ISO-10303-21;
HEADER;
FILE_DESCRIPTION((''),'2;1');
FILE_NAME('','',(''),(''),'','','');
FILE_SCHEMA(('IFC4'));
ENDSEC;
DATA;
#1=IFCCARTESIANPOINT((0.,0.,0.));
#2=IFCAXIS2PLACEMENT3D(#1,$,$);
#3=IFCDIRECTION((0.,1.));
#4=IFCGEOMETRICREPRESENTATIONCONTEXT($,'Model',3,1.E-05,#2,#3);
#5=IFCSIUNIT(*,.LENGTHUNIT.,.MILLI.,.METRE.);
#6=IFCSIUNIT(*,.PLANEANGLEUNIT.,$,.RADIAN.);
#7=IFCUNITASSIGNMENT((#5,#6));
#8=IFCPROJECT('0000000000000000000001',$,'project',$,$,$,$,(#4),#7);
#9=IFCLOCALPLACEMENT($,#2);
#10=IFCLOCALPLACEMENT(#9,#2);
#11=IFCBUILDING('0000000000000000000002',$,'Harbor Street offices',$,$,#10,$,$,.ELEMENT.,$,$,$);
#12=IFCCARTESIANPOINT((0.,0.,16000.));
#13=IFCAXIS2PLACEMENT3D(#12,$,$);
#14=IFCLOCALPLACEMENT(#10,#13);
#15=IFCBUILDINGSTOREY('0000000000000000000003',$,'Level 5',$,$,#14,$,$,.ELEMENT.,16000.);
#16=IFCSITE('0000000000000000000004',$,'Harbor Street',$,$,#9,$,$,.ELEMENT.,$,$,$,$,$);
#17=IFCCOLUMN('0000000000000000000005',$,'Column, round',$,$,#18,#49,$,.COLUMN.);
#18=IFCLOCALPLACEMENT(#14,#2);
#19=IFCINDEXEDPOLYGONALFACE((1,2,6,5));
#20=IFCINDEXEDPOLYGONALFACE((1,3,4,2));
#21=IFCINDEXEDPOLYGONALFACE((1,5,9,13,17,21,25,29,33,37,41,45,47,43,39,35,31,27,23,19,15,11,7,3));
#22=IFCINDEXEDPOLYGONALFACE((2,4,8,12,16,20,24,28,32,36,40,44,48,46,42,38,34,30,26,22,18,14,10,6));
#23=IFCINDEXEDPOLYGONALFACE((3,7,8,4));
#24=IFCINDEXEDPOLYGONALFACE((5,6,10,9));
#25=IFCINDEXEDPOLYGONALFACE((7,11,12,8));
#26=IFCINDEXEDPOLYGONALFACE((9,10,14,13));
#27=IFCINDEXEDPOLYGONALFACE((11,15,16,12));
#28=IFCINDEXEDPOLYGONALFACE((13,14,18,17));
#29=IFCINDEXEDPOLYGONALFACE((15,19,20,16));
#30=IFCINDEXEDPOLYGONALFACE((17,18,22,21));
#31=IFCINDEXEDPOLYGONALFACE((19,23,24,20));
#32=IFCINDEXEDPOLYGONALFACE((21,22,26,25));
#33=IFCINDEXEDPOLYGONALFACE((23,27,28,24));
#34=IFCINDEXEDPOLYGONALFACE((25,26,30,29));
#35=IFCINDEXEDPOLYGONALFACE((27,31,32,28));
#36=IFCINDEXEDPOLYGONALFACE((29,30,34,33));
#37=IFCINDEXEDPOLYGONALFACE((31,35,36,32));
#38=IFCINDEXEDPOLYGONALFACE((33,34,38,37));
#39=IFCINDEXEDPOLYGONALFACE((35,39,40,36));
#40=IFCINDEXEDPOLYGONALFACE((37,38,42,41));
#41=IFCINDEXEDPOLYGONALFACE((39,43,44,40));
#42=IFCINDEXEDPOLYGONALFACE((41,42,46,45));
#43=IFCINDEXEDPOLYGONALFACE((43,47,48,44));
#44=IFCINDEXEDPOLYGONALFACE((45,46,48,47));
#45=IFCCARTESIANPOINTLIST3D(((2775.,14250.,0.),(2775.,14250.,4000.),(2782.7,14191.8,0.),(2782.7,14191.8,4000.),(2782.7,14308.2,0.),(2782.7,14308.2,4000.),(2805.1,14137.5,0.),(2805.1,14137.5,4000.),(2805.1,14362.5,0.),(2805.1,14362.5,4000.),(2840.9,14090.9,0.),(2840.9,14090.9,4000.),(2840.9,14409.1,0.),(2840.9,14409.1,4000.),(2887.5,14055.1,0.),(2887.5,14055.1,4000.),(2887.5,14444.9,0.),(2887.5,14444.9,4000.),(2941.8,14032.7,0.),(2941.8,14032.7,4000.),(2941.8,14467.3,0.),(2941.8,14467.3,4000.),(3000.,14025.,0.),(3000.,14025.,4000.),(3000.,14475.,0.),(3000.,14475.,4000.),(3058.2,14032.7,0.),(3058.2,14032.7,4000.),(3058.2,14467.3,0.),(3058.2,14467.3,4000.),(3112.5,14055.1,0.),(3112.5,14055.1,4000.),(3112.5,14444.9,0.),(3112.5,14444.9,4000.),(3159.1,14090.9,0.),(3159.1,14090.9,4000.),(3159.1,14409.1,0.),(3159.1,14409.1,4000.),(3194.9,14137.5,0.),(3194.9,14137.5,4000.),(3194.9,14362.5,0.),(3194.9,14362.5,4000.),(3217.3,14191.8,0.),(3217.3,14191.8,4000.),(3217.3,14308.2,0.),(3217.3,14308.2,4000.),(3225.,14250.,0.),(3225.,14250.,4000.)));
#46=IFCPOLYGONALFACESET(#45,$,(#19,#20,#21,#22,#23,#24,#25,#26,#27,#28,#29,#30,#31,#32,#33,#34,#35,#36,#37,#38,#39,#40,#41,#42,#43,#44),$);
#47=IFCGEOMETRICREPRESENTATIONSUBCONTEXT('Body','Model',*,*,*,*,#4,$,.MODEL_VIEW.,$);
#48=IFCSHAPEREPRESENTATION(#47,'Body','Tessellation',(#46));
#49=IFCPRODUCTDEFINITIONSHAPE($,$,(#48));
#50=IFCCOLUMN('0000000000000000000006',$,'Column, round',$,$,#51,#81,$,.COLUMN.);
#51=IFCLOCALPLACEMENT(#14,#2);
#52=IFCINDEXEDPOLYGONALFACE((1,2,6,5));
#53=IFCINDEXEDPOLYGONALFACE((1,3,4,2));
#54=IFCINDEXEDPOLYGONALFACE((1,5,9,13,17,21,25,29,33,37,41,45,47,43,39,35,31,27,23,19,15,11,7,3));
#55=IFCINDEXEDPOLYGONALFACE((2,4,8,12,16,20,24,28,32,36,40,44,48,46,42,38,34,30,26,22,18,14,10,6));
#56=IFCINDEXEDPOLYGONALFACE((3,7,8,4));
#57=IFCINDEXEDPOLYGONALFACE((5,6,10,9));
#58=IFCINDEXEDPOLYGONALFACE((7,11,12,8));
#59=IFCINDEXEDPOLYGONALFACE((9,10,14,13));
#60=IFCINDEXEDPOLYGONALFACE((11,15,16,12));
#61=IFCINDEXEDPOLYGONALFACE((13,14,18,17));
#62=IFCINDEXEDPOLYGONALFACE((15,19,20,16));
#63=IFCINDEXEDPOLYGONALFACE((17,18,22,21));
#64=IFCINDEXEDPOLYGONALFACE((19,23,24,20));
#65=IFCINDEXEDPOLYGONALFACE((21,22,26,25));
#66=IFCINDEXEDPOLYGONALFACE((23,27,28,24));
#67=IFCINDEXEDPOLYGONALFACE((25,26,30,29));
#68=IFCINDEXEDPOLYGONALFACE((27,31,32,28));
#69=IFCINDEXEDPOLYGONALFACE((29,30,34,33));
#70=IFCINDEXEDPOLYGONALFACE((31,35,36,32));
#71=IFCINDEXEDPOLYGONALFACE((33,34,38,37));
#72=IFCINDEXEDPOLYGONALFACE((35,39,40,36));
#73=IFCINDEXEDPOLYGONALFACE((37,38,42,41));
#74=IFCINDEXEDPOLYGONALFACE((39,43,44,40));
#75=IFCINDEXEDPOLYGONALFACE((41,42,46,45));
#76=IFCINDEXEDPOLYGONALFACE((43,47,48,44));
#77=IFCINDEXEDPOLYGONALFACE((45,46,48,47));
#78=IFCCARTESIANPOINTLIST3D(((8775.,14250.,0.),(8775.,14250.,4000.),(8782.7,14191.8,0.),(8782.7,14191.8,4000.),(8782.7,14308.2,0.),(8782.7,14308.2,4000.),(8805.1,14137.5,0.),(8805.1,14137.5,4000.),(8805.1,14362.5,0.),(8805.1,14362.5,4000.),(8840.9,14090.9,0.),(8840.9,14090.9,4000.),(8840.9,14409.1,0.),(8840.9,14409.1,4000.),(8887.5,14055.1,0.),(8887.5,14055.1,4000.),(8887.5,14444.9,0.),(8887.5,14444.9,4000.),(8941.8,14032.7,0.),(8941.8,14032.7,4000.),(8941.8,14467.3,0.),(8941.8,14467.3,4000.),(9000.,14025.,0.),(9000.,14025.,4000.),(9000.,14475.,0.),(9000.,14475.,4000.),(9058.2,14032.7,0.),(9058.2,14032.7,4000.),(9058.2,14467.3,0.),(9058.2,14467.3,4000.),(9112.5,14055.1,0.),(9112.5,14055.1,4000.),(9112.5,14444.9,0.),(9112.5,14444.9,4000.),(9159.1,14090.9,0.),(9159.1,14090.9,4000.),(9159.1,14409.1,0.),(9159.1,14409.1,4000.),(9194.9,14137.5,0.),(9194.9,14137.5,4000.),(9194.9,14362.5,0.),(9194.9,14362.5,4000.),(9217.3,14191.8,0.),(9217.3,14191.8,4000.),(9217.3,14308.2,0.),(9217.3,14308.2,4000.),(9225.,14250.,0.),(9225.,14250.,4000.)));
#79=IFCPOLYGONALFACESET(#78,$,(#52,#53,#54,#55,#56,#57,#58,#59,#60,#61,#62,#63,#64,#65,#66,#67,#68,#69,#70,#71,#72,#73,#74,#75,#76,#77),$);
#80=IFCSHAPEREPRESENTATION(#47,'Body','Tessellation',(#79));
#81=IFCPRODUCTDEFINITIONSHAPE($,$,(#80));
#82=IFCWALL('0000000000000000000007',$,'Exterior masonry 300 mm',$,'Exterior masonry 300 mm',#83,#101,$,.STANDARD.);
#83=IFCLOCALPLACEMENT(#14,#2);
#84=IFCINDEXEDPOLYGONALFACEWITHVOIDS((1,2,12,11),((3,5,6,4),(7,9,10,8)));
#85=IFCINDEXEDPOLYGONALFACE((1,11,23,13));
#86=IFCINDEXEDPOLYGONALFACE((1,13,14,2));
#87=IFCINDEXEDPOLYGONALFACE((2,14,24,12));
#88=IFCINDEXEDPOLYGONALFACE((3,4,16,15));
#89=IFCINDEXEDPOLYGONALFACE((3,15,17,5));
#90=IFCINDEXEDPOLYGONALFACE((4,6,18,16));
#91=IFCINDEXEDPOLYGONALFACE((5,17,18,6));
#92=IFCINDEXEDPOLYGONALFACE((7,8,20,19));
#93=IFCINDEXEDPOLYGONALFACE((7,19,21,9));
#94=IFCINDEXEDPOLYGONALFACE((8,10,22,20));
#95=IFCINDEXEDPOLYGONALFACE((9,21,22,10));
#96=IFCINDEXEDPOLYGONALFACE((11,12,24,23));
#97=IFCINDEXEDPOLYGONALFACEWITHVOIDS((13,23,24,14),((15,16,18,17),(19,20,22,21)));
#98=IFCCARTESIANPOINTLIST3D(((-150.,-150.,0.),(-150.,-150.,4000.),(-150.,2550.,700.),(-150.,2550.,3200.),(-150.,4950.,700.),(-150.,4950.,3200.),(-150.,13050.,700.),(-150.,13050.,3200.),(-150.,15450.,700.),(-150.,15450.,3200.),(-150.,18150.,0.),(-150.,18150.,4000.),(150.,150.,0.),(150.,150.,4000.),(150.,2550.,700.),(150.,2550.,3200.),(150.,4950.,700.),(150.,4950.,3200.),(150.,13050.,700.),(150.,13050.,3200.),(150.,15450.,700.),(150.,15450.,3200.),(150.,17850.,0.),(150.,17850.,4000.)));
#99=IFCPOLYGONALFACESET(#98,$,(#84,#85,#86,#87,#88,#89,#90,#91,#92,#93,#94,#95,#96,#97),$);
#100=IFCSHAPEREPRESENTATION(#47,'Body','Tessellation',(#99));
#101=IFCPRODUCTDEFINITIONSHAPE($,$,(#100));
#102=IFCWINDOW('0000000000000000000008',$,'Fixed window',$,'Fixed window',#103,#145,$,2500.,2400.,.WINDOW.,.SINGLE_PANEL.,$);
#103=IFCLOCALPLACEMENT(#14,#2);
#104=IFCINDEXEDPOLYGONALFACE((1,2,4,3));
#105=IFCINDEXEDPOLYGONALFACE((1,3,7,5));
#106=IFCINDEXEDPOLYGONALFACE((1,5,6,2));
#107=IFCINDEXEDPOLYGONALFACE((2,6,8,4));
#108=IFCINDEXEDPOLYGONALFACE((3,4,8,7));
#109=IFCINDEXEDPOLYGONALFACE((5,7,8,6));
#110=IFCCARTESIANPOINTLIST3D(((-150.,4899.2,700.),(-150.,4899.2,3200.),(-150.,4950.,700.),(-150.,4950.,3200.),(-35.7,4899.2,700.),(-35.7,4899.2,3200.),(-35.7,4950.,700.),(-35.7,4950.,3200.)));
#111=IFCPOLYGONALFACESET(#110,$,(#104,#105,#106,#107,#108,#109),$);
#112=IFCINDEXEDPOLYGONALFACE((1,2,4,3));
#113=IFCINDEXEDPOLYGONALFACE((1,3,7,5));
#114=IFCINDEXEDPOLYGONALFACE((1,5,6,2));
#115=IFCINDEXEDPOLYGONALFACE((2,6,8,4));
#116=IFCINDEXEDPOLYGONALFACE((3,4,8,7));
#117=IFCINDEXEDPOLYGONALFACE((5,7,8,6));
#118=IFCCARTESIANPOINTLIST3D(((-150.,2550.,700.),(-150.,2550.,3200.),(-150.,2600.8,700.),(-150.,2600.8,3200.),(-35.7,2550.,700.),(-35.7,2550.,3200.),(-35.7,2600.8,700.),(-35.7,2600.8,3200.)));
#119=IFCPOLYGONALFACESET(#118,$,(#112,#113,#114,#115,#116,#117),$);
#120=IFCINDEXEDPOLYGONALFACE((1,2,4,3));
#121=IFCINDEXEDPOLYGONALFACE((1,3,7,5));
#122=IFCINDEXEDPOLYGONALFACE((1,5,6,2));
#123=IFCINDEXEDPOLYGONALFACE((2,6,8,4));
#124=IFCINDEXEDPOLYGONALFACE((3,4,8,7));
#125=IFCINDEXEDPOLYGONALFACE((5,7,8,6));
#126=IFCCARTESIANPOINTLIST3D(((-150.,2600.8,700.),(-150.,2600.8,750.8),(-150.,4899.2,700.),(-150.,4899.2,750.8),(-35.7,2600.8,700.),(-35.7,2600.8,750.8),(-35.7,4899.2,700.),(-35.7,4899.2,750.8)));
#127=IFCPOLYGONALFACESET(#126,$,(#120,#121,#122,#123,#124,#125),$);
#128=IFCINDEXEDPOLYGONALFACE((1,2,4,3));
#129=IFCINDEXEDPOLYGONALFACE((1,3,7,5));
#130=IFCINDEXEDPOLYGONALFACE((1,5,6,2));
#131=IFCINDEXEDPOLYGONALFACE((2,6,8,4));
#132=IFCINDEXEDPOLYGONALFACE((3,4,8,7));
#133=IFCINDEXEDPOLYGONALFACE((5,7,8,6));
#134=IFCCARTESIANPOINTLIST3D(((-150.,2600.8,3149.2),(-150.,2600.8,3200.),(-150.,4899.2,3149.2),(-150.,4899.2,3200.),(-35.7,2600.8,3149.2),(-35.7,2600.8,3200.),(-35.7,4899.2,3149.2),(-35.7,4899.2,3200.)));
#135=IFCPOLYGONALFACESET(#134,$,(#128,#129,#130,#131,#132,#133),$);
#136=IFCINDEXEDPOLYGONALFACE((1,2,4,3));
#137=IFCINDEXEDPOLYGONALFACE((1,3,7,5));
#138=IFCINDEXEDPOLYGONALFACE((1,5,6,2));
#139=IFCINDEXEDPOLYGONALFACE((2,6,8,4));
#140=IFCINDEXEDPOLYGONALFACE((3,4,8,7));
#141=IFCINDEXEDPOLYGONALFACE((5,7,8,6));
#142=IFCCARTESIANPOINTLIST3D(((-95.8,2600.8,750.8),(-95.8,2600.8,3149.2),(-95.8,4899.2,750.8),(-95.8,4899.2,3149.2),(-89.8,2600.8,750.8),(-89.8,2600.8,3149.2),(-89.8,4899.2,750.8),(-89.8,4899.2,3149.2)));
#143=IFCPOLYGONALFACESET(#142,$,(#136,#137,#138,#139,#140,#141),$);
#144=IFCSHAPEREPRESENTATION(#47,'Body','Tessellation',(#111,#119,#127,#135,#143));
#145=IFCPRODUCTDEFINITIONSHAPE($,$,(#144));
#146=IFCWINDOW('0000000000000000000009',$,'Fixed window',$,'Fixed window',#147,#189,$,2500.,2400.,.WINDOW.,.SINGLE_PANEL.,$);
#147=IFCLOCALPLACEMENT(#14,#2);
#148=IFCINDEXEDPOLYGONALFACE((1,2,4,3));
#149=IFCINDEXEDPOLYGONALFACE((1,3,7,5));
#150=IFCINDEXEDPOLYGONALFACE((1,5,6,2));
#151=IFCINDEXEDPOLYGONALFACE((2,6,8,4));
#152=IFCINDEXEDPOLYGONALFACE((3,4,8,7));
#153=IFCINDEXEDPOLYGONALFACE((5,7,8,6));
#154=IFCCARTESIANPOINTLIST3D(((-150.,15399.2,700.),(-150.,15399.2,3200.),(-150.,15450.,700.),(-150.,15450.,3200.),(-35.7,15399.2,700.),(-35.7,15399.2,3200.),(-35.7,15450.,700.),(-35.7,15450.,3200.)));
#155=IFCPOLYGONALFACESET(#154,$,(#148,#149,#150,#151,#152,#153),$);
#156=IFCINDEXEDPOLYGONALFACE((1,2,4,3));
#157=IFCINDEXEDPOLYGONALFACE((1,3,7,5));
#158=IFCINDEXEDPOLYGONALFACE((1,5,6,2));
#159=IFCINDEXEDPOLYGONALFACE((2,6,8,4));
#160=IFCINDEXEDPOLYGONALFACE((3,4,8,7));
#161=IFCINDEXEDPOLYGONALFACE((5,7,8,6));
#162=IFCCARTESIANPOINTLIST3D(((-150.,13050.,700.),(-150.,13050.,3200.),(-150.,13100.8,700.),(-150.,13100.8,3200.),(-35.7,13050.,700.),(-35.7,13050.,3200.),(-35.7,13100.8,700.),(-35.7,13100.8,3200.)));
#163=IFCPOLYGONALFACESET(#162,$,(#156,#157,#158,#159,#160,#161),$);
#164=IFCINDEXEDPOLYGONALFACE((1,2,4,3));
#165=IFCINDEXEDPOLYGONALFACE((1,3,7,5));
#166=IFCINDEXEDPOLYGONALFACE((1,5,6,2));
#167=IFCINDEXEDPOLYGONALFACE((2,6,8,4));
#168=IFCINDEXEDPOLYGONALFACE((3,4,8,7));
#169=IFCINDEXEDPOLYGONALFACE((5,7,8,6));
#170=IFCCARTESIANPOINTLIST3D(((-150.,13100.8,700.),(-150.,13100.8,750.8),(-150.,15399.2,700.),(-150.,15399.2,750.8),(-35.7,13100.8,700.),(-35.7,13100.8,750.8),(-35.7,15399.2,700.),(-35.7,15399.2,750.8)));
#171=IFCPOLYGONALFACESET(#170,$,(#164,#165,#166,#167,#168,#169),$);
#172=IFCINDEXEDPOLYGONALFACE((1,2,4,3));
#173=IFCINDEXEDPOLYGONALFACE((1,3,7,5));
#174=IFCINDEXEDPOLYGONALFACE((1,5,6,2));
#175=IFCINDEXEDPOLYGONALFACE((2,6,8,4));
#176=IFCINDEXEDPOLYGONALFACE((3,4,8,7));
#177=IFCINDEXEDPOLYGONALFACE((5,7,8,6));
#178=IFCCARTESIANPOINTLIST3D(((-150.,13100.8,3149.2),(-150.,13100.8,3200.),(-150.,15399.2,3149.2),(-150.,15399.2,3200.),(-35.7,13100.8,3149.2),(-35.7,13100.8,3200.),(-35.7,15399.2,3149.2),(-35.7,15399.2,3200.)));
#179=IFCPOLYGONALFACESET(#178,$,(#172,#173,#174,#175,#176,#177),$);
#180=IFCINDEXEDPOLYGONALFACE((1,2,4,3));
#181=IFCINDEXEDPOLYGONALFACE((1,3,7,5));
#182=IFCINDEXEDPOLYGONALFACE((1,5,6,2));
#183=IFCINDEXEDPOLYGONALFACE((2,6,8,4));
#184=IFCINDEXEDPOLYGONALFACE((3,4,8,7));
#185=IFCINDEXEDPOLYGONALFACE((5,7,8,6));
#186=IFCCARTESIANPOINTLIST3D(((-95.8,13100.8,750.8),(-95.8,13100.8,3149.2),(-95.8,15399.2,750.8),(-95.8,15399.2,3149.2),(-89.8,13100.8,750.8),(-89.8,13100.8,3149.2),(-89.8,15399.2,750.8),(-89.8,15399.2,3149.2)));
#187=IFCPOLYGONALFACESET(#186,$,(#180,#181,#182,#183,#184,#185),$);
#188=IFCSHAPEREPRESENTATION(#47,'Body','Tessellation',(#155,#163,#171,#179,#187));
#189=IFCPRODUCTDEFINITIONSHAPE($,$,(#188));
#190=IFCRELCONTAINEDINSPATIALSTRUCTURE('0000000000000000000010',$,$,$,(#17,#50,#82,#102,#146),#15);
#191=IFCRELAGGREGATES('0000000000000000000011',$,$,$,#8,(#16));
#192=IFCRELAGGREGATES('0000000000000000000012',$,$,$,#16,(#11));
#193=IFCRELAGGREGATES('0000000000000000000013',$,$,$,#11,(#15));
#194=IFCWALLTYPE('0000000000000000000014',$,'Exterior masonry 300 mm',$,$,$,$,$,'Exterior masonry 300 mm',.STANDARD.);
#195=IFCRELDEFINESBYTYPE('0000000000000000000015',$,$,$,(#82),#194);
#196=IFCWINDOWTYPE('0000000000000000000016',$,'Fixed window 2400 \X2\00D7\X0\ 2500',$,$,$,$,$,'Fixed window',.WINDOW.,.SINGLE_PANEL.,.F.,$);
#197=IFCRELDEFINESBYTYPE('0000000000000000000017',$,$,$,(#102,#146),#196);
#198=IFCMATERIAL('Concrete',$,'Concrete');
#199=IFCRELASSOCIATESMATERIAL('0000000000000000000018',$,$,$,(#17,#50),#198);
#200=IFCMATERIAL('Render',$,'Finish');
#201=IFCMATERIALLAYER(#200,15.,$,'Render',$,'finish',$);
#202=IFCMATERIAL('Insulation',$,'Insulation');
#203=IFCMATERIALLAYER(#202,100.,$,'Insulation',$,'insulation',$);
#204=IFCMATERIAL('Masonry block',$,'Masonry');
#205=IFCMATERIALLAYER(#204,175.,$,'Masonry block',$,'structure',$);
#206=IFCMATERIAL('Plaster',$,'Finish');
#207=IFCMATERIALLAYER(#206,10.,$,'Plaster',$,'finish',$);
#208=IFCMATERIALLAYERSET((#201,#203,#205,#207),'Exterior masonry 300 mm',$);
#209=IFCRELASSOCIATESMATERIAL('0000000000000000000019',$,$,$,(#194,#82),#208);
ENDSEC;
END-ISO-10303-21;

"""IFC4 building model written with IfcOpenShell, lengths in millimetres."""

from ifc_helpers import new_model, si_unit, direction, frame, origin, origin_with_axes, origin_2d, place, context, subcontext, project, spatial, polyline, circle, outline, extrude, material, layer, layer_set, layer_usage, type_object, element, fill, save


model = new_model("IFC4")

# Units and contexts
model_context = context("Model", 3, precision=1e-05, world=origin(), true_north=direction((0.0, 1.0)))
body_context = subcontext(model_context, "Body", "Model", "MODEL_VIEW")
ifc_project = project(units=[si_unit("LENGTHUNIT", "METRE", prefix="MILLI"), si_unit("PLANEANGLEUNIT", "RADIAN")], contexts=[model_context])

# Site, building, storey
site_placement = place(None, origin())
site = spatial("IfcSite", under=ifc_project, at=site_placement, Name="Harbor Street", CompositionType="ELEMENT")
building_placement = place(site_placement, origin())
building = spatial("IfcBuilding", under=site, at=building_placement, Name="Harbor Street offices", CompositionType="ELEMENT")
storey_placement = place(building_placement, frame((0.0, 0.0, 16000.0)))
storey = spatial("IfcBuildingStorey", under=building, at=storey_placement, Name="Level 5", CompositionType="ELEMENT", Elevation=16000.0)

# Columns
ifc_material_1 = material(Name="Concrete", Category="Concrete")
for number, where, z_axis, x_axis, name in (
    (1, (3000.0, 14250.0, 0.0), (0.0, 0.0, 1.0), (1.0, 0.0, 0.0), "Column, round"),
    (2, (9000.0, 14250.0, 0.0), (0.0, 0.0, 1.0), (1.0, 0.0, 0.0), "Column, round"),
):
    element("IfcColumn", number, at=place(storey_placement, frame(where, z_axis=z_axis, x_axis=x_axis)), inside=storey, material=ifc_material_1, Name=name, PredefinedType="COLUMN", context=body_context, shape_type="SweptSolid", body=[
        extrude(circle(Radius=225.0, at=origin_2d()), origin(), (0.0, 0.0, 1.0), 4000.0),
    ])

# Wall, openings, windows
ifc_material_2 = material(Name="Render", Category="Finish")
ifc_layer_1 = layer(ifc_material_2, 15.0, Name="Render", Category="finish")
ifc_material_3 = material(Name="Insulation", Category="Insulation")
ifc_layer_2 = layer(ifc_material_3, 100.0, Name="Insulation", Category="insulation")
ifc_material_4 = material(Name="Masonry block", Category="Masonry")
ifc_layer_3 = layer(ifc_material_4, 175.0, Name="Masonry block", Category="structure")
ifc_material_5 = material(Name="Plaster", Category="Finish")
ifc_layer_4 = layer(ifc_material_5, 10.0, Name="Plaster", Category="finish")
ifc_layer_set_1 = layer_set([ifc_layer_1, ifc_layer_2, ifc_layer_3, ifc_layer_4], Name="Exterior masonry 300 mm")
ifc_layer_usage_1 = layer_usage(ifc_layer_set_1, "AXIS2", "POSITIVE", -150.0)
wall_type_1 = type_object("IfcWallType", Name="Exterior masonry 300 mm", ElementType="Exterior masonry 300 mm", PredefinedType="STANDARD", material=ifc_layer_set_1)
wall_1_placement = place(storey_placement, frame((0.0, 18000.0, 0.0), z_axis=(0.0, 0.0, 1.0), x_axis=(0.0, -1.0, 0.0)))
wall_1 = element("IfcWall", 3, at=wall_1_placement, inside=storey, type_object=wall_type_1, material=ifc_layer_usage_1, Name="Exterior masonry 300 mm", ObjectType="Exterior masonry 300 mm", PredefinedType="STANDARD", context=body_context, shape_type="SweptSolid", body=[
    extrude(outline(polyline([(-150.0, -150.0), (18150.0, -150.0), (17850.0, 150.0), (150.0, 150.0), (-150.0, -150.0)])), origin(), (0.0, 0.0, 1.0), 4000.0),
])
opening_1_placement = place(wall_1_placement, frame((13050.0, 0.0, 700.0), z_axis=(0.0, 0.0, 1.0), x_axis=(1.0, 0.0, 0.0)))
opening_1 = element("IfcOpeningElement", 4, at=opening_1_placement, cuts=wall_1, PredefinedType="OPENING", context=body_context, shape_type="SweptSolid", body=[
    extrude(outline(polyline([(0.0, -160.0), (2400.0, -160.0), (2400.0, 160.0), (0.0, 160.0), (0.0, -160.0)])), origin(), (0.0, 0.0, 1.0), 2500.0),
])
opening_2_placement = place(wall_1_placement, frame((2550.0, 0.0, 700.0), z_axis=(0.0, 0.0, 1.0), x_axis=(1.0, 0.0, 0.0)))
opening_2 = element("IfcOpeningElement", 5, at=opening_2_placement, cuts=wall_1, PredefinedType="OPENING", context=body_context, shape_type="SweptSolid", body=[
    extrude(outline(polyline([(0.0, -160.0), (2400.0, -160.0), (2400.0, 160.0), (0.0, 160.0), (0.0, -160.0)])), origin(), (0.0, 0.0, 1.0), 2500.0),
])
window_type = type_object("IfcWindowType", Name="Fixed window 2400 × 2500", ElementType="Fixed window", ParameterTakesPrecedence=False, PartitioningType="SINGLE_PANEL", PredefinedType="WINDOW")
window_1_placement = place(opening_1_placement, origin_with_axes())
window_1 = element("IfcWindow", 6, at=window_1_placement, inside=storey, type_object=window_type, Name="Fixed window", ObjectType="Fixed window", OverallHeight=2500.0, OverallWidth=2400.0, PartitioningType="SINGLE_PANEL", PredefinedType="WINDOW", context=body_context, shape_type="SweptSolid", body=[
    extrude(outline(polyline([(0.0, -150.0), (50.8, -150.0), (50.8, -35.7), (0.0, -35.7), (0.0, -150.0)])), origin(), (0.0, 0.0, 1.0), 2500.0),
    extrude(outline(polyline([(2349.2, -150.0), (2400.0, -150.0), (2400.0, -35.7), (2349.2, -35.7), (2349.2, -150.0)])), origin(), (0.0, 0.0, 1.0), 2500.0),
    extrude(outline(polyline([(50.8, -150.0), (2349.2, -150.0), (2349.2, -35.7), (50.8, -35.7), (50.8, -150.0)])), origin(), (0.0, 0.0, 1.0), 50.8),
    extrude(outline(polyline([(50.8, -150.0), (2349.2, -150.0), (2349.2, -35.7), (50.8, -35.7), (50.8, -150.0)])), frame((0.0, 0.0, 2449.2)), (0.0, 0.0, 1.0), 50.8),
    extrude(outline(polyline([(50.8, -95.8), (2349.2, -95.8), (2349.2, -89.8), (50.8, -89.8), (50.8, -95.8)])), frame((0.0, 0.0, 50.8)), (0.0, 0.0, 1.0), 2398.4),
])
fill(opening_1, window_1)
window_2_placement = place(opening_2_placement, origin_with_axes())
window_2 = element("IfcWindow", 7, at=window_2_placement, inside=storey, type_object=window_type, Name="Fixed window", ObjectType="Fixed window", OverallHeight=2500.0, OverallWidth=2400.0, PartitioningType="SINGLE_PANEL", PredefinedType="WINDOW", context=body_context, shape_type="SweptSolid", body=[
    extrude(outline(polyline([(0.0, -150.0), (50.8, -150.0), (50.8, -35.7), (0.0, -35.7), (0.0, -150.0)])), origin(), (0.0, 0.0, 1.0), 2500.0),
    extrude(outline(polyline([(2349.2, -150.0), (2400.0, -150.0), (2400.0, -35.7), (2349.2, -35.7), (2349.2, -150.0)])), origin(), (0.0, 0.0, 1.0), 2500.0),
    extrude(outline(polyline([(50.8, -150.0), (2349.2, -150.0), (2349.2, -35.7), (50.8, -35.7), (50.8, -150.0)])), origin(), (0.0, 0.0, 1.0), 50.8),
    extrude(outline(polyline([(50.8, -150.0), (2349.2, -150.0), (2349.2, -35.7), (50.8, -35.7), (50.8, -150.0)])), frame((0.0, 0.0, 2449.2)), (0.0, 0.0, 1.0), 50.8),
    extrude(outline(polyline([(50.8, -95.8), (2349.2, -95.8), (2349.2, -89.8), (50.8, -89.8), (50.8, -95.8)])), frame((0.0, 0.0, 50.8)), (0.0, 0.0, 1.0), 2398.4),
])
fill(opening_2, window_2)

save(model, "model.ifc")
